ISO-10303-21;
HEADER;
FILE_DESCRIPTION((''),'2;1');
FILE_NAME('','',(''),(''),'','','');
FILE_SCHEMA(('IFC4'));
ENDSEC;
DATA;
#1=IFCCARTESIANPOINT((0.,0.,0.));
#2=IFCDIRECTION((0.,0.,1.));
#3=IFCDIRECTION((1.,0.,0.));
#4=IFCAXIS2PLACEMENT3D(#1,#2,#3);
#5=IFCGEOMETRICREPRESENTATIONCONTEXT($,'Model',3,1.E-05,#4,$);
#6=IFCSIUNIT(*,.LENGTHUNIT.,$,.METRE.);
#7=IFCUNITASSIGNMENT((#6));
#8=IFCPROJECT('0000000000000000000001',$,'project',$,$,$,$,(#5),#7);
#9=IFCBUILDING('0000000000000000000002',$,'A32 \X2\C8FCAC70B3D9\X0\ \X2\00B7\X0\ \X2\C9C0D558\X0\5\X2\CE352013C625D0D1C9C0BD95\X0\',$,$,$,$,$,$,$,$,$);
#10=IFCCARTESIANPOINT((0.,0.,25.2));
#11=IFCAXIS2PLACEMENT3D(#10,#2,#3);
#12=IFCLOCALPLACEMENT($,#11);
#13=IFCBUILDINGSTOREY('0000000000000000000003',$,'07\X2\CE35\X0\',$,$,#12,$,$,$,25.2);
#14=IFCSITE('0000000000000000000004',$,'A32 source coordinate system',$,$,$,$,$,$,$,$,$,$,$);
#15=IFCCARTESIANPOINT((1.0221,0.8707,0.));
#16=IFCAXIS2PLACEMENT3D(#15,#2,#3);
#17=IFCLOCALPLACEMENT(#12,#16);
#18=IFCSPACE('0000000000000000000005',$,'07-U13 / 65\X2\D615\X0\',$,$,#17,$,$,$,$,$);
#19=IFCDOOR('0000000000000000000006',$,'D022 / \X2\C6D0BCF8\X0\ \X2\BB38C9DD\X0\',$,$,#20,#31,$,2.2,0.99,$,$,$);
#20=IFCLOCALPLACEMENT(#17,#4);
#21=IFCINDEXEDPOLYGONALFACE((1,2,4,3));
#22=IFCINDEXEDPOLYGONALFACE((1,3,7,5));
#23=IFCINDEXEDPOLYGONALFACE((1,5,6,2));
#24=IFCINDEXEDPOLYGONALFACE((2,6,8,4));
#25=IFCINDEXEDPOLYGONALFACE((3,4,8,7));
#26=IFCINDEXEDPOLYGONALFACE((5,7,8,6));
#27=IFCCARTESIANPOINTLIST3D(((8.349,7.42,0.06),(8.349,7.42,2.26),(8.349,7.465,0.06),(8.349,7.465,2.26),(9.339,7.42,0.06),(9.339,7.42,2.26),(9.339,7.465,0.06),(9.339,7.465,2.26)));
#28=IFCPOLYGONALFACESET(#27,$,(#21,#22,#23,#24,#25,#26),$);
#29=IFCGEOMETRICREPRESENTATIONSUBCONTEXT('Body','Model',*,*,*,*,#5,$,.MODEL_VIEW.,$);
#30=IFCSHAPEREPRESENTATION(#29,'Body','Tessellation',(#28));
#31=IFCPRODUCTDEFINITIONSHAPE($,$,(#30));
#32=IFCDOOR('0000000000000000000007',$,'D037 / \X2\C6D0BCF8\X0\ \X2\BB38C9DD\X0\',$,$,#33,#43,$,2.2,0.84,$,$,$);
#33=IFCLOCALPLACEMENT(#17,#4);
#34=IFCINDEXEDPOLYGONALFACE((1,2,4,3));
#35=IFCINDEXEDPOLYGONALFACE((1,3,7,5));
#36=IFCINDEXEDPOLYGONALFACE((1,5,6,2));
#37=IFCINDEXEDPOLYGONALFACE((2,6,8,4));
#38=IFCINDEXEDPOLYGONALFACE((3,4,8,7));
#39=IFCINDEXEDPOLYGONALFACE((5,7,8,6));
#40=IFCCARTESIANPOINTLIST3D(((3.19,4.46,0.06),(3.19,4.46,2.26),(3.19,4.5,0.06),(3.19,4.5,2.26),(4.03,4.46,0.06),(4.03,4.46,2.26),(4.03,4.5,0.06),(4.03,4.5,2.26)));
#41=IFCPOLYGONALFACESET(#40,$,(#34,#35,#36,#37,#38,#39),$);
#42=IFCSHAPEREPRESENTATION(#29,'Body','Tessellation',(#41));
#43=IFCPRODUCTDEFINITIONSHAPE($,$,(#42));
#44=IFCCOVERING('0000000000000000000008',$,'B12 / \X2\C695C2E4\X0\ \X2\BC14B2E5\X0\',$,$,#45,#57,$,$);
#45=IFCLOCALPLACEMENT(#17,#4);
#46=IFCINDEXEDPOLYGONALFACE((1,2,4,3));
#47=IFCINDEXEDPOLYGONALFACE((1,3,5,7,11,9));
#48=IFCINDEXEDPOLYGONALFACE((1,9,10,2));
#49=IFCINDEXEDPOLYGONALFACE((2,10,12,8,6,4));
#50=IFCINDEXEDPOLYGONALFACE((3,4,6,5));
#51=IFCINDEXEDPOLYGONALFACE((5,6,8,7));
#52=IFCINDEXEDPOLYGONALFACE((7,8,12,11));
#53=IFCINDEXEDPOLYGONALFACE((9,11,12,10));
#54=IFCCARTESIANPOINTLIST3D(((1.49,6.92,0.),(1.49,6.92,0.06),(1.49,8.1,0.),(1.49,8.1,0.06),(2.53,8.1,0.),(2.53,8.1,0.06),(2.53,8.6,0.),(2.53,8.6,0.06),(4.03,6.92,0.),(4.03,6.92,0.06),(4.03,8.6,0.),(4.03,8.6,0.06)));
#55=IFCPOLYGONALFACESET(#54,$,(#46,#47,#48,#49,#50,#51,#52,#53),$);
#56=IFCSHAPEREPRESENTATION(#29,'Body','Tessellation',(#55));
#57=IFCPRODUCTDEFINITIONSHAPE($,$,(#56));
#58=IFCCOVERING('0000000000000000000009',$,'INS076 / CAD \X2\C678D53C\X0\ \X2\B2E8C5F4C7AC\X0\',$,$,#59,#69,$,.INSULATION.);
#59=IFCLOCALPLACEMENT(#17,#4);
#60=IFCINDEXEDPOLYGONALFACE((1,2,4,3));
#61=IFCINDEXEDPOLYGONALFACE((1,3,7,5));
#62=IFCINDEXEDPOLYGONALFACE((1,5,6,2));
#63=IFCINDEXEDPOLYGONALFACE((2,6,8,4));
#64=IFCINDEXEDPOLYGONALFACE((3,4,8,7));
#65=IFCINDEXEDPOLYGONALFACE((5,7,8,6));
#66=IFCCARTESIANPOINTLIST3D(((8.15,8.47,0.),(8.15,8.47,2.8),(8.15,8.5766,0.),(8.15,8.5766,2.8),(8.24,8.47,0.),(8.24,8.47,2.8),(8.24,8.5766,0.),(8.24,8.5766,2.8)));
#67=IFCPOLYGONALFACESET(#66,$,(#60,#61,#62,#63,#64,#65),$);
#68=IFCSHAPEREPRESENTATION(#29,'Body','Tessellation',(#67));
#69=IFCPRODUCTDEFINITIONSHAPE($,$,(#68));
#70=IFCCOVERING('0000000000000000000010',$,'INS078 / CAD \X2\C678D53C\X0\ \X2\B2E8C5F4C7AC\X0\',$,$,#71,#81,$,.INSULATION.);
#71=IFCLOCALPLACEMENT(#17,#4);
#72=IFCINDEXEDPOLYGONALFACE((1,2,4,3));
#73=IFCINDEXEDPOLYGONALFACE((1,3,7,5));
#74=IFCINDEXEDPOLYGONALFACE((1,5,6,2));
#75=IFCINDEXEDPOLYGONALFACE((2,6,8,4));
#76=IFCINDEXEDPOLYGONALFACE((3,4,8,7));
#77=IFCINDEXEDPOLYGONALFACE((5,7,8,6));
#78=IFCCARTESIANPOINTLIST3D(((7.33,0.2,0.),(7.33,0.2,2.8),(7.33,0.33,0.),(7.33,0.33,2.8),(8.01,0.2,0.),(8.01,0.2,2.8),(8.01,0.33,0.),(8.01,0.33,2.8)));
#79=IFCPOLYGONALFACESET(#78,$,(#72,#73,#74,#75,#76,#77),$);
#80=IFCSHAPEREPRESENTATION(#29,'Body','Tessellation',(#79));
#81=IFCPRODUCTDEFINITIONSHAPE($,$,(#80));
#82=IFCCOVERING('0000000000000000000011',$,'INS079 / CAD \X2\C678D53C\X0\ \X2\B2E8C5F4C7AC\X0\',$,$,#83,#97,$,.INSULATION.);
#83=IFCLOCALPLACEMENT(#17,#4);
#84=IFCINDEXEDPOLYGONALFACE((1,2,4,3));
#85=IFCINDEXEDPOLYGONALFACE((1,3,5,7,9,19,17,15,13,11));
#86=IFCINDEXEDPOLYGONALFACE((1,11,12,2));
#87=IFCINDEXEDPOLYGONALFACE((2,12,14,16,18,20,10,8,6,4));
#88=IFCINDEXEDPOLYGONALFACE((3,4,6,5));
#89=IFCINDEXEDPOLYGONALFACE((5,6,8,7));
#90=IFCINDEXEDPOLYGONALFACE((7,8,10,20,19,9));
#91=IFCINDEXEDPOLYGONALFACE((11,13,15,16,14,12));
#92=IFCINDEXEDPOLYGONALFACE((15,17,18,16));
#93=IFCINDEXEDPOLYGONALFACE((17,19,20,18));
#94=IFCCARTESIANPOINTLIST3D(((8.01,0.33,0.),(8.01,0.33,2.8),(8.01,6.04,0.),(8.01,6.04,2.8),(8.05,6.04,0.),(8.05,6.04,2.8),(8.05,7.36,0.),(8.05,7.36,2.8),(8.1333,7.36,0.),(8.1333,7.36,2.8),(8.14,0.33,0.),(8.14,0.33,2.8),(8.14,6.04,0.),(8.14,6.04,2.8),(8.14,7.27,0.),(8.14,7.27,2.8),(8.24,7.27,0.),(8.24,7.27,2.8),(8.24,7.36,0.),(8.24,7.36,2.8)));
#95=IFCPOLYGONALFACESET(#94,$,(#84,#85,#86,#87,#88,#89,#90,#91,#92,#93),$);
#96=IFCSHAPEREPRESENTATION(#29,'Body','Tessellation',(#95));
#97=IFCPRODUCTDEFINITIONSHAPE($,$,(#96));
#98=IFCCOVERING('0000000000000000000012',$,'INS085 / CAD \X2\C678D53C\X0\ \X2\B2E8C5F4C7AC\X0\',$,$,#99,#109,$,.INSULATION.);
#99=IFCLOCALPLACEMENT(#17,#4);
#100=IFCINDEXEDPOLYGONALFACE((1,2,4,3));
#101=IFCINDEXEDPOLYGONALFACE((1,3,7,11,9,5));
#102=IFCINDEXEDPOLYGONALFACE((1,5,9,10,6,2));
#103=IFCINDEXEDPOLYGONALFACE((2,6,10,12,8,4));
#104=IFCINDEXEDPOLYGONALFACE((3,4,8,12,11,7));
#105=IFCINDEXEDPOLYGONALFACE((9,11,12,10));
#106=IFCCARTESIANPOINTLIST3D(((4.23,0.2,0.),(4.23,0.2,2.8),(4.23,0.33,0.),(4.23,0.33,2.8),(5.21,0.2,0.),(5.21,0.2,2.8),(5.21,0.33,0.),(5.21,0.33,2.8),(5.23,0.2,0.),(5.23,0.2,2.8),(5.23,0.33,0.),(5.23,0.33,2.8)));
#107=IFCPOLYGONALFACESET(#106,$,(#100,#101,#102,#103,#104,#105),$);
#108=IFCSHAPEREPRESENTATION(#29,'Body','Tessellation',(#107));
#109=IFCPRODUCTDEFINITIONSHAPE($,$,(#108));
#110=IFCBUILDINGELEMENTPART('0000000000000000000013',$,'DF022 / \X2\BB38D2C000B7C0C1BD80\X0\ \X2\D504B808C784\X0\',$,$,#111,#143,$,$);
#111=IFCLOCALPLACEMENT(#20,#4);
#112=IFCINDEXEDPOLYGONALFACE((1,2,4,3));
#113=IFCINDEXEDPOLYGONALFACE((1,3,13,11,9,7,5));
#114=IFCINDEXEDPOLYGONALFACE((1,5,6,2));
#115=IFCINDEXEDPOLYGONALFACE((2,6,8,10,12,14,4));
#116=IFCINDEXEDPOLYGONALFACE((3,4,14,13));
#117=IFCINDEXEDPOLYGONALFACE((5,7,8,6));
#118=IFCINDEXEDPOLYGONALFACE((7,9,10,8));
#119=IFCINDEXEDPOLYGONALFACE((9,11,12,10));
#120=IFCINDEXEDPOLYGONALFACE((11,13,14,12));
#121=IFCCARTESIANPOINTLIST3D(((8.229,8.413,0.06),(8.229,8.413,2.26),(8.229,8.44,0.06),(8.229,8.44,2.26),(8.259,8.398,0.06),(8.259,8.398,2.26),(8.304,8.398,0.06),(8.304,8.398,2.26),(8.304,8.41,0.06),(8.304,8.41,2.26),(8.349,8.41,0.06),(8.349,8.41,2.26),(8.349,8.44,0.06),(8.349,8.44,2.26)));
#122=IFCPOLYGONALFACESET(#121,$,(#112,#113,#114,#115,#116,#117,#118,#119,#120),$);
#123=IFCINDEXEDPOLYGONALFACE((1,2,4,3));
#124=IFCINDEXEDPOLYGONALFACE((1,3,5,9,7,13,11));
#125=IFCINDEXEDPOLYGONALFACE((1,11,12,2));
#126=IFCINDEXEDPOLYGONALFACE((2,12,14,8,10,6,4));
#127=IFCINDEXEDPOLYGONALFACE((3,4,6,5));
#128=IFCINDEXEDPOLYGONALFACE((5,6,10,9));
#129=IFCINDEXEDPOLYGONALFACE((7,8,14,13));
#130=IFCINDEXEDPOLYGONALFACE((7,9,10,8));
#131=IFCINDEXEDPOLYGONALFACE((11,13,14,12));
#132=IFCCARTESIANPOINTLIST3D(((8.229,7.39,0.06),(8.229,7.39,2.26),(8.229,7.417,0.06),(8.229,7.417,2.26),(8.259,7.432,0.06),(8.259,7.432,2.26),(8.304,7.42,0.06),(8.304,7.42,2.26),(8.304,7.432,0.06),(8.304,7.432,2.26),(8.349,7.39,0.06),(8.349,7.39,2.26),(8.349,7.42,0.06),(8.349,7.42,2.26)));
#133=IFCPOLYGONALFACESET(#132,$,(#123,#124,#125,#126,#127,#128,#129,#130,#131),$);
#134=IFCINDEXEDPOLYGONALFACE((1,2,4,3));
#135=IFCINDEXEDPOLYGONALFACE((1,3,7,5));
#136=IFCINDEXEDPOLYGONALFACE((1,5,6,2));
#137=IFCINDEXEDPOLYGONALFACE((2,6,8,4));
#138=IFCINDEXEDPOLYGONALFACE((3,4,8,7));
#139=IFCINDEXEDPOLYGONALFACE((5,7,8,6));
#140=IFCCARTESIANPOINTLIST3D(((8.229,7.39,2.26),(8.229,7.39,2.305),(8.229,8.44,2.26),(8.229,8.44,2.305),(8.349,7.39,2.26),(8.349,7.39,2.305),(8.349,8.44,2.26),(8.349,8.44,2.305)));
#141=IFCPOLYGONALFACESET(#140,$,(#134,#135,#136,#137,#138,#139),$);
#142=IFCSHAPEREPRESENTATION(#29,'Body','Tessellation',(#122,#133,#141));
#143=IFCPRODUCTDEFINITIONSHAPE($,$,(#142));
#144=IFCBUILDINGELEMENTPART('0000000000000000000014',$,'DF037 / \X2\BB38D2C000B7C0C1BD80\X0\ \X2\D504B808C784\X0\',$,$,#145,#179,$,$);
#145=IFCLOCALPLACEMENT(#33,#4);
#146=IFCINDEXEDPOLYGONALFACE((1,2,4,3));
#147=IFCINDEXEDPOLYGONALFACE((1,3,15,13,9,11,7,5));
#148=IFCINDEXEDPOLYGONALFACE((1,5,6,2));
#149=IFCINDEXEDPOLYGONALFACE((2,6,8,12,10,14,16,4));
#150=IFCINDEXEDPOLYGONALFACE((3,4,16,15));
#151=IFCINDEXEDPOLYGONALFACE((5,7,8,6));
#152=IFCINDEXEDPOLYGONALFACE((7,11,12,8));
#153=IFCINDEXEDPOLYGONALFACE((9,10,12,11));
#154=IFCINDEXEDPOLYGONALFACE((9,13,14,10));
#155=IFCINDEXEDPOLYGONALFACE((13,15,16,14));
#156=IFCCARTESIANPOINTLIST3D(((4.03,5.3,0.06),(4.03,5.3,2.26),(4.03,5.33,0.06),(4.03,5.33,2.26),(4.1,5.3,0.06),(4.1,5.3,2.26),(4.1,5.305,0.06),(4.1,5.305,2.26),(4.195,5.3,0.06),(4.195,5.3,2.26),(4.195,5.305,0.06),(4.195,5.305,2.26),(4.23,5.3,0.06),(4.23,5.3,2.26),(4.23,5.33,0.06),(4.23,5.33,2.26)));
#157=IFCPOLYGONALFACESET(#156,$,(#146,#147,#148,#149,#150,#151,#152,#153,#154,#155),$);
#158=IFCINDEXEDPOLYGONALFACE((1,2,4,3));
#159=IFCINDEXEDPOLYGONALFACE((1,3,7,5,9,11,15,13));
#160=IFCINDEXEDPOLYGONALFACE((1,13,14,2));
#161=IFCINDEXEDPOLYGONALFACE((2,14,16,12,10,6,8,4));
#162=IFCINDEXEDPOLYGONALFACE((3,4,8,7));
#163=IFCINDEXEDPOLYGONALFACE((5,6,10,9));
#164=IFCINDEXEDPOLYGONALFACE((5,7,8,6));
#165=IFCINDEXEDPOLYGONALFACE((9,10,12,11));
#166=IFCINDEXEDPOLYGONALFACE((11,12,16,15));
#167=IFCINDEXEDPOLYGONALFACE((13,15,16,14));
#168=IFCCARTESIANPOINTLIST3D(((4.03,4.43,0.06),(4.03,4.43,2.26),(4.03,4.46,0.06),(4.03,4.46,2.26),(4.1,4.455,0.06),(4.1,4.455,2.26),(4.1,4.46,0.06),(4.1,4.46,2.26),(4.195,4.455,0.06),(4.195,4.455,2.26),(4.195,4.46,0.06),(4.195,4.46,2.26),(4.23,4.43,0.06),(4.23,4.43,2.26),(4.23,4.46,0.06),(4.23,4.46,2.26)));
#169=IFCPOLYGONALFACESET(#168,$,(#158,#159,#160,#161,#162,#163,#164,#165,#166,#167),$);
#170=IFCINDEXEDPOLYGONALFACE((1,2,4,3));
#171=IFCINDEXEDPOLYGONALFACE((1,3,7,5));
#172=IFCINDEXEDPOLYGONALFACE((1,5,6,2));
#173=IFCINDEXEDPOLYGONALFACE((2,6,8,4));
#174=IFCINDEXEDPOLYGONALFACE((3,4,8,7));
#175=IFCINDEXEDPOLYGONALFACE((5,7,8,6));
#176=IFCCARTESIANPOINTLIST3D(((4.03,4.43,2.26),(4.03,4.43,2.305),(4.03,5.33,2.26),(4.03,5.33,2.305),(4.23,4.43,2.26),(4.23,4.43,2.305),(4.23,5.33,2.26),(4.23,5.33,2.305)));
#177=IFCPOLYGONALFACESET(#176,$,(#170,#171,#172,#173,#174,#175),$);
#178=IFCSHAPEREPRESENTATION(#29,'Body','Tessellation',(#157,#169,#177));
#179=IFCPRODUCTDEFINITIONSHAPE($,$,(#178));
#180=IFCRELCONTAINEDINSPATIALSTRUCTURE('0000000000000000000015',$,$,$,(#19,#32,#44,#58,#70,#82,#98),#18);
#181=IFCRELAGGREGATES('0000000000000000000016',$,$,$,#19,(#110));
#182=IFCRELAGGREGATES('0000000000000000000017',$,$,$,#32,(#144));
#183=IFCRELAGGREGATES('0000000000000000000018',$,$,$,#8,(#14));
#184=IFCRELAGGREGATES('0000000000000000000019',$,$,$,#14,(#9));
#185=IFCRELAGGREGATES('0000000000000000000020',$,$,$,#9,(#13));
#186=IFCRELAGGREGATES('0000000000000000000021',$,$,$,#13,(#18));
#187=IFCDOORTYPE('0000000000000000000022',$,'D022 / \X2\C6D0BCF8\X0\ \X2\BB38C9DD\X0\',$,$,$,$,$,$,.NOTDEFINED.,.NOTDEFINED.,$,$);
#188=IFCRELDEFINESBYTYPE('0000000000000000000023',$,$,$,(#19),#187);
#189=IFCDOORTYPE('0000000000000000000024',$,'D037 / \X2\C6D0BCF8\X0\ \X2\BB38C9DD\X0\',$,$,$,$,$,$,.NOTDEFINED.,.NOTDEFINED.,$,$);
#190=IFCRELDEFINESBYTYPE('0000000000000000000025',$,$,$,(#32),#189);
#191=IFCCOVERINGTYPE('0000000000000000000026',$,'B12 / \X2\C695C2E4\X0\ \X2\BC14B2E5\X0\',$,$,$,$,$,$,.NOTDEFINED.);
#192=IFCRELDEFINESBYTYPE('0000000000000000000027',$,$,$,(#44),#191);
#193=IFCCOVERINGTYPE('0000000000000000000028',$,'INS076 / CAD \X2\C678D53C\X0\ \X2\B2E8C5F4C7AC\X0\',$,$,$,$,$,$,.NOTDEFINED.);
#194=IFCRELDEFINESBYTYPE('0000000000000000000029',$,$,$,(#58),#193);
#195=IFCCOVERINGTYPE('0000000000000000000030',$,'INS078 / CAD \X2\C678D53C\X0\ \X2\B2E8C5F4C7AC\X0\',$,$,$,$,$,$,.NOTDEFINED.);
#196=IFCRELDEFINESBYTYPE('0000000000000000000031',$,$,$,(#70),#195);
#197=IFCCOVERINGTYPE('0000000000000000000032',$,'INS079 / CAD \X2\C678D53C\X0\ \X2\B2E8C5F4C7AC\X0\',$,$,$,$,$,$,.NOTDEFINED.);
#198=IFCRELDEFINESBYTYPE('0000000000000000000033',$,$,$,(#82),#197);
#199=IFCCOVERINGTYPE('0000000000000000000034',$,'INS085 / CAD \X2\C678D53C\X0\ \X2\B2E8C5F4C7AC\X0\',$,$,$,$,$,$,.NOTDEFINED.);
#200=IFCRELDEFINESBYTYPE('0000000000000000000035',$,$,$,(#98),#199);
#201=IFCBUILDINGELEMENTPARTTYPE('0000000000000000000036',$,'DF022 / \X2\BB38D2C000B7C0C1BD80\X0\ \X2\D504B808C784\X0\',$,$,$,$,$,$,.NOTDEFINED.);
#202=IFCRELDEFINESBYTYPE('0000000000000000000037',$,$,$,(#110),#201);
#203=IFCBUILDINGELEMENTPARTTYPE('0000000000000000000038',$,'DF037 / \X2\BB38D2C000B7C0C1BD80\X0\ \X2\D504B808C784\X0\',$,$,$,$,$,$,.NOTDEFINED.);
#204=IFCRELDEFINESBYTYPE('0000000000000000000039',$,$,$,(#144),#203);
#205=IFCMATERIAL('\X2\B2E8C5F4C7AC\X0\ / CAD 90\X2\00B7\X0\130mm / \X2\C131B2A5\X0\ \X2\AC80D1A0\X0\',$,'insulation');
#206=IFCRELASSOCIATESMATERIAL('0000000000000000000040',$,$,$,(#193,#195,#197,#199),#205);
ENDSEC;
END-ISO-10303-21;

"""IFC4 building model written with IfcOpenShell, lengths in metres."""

from ifc_helpers import new_model, si_unit, frame, origin, origin_with_axes, place, context, subcontext, project, spatial, polyline, outline, extrude, source, transform, mapped, material, type_object, type_shapes, element, aggregate, save


model = new_model("IFC4")

# Units and contexts
model_context = context("Model", 3, precision=1e-05, world=origin_with_axes())
body_context = subcontext(model_context, "Body", "Model", "MODEL_VIEW")
ifc_project = project(units=[si_unit("LENGTHUNIT", "METRE")], contexts=[model_context])

# Site, building, storey
site = spatial("IfcSite", under=ifc_project, Name="A32 source coordinate system")
building = spatial("IfcBuilding", under=site, Name="A32 주거동 · 지하5층–옥탑지붕")
storey_placement = place(None, frame((0.0, 0.0, 25.2), z_axis=(0.0, 0.0, 1.0), x_axis=(1.0, 0.0, 0.0)))
storey = spatial("IfcBuildingStorey", under=building, at=storey_placement, Name="07층", Elevation=25.2)

# Shared definitions
space_placement = place(storey_placement, frame((1.0221, 0.8707, 0.0), z_axis=(0.0, 0.0, 1.0), x_axis=(1.0, 0.0, 0.0)))
space = spatial("IfcSpace", under=storey, at=space_placement, Name="07-U13 / 65형")

# Doors
door_type_1 = type_object("IfcDoorType", Name="D022 / 원본 문짝", OperationType="NOTDEFINED", PredefinedType="NOTDEFINED")
shared_shape_1 = source(origin(), body_context, "Body", "SweptSolid", [
    extrude(outline(polyline([(9.339, 7.465), (9.339, 7.42), (8.349, 7.42), (8.349, 7.465), (9.339, 7.465)])), frame((0.0, 0.0, 0.06)), (0.0, 0.0, 1.0), 2.2),
])
type_shapes(door_type_1, [shared_shape_1])
door_1_placement = place(space_placement, origin_with_axes())
door_1 = element("IfcDoor", 1, at=door_1_placement, inside=space, type_object=door_type_1, Name="D022 / 원본 문짝", OverallHeight=2.2, OverallWidth=0.99, context=body_context, shape_type="MappedRepresentation", body=[
    mapped(shared_shape_1, transform((0.0, 0.0, 0.0), scale=1.0)),
])
door_type_2 = type_object("IfcDoorType", Name="D037 / 원본 문짝", OperationType="NOTDEFINED", PredefinedType="NOTDEFINED")
shared_shape_2 = source(origin(), body_context, "Body", "SweptSolid", [
    extrude(outline(polyline([(4.03, 4.46), (3.19, 4.46), (3.19, 4.5), (4.03, 4.5), (4.03, 4.46)])), frame((0.0, 0.0, 0.06)), (0.0, 0.0, 1.0), 2.2),
])
type_shapes(door_type_2, [shared_shape_2])
door_2_placement = place(space_placement, origin_with_axes())
door_2 = element("IfcDoor", 2, at=door_2_placement, inside=space, type_object=door_type_2, Name="D037 / 원본 문짝", OverallHeight=2.2, OverallWidth=0.84, context=body_context, shape_type="MappedRepresentation", body=[
    mapped(shared_shape_2, transform((0.0, 0.0, 0.0), scale=1.0)),
])

# Coverings
covering_type_1 = type_object("IfcCoveringType", Name="B12 / 욕실 바닥", PredefinedType="NOTDEFINED")
shared_shape_3 = source(origin(), body_context, "Body", "SweptSolid", [
    extrude(outline(polyline([(2.53, 8.6), (4.03, 8.6), (4.03, 6.92), (1.49, 6.92), (1.49, 8.1), (2.53, 8.1), (2.53, 8.6)])), origin(), (0.0, 0.0, 1.0), 0.06),
])
type_shapes(covering_type_1, [shared_shape_3])
covering_1_placement = place(space_placement, origin_with_axes())
element("IfcCovering", 3, at=covering_1_placement, inside=space, type_object=covering_type_1, Name="B12 / 욕실 바닥", context=body_context, shape_type="MappedRepresentation", body=[
    mapped(shared_shape_3, transform((0.0, 0.0, 0.0), scale=1.0)),
])
ifc_material = material(Name="단열재 / CAD 90·130mm / 성능 검토", Category="insulation")
covering_type_2 = type_object("IfcCoveringType", Name="INS076 / CAD 외피 단열재", PredefinedType="NOTDEFINED", material=ifc_material)
shared_shape_4 = source(origin(), body_context, "Body", "SweptSolid", [
    extrude(outline(polyline([(8.24, 8.5766), (8.24, 8.47), (8.15, 8.47), (8.15, 8.5766), (8.24, 8.5766)])), origin(), (0.0, 0.0, 1.0), 2.8),
])
type_shapes(covering_type_2, [shared_shape_4])
covering_2_placement = place(space_placement, origin_with_axes())
element("IfcCovering", 4, at=covering_2_placement, inside=space, type_object=covering_type_2, Name="INS076 / CAD 외피 단열재", PredefinedType="INSULATION", context=body_context, shape_type="MappedRepresentation", body=[
    mapped(shared_shape_4, transform((0.0, 0.0, 0.0), scale=1.0)),
])
covering_type_3 = type_object("IfcCoveringType", Name="INS078 / CAD 외피 단열재", PredefinedType="NOTDEFINED", material=ifc_material)
shared_shape_5 = source(origin(), body_context, "Body", "SweptSolid", [
    extrude(outline(polyline([(8.01, 0.2), (7.33, 0.2), (7.33, 0.33), (8.01, 0.33), (8.01, 0.2)])), origin(), (0.0, 0.0, 1.0), 2.8),
])
type_shapes(covering_type_3, [shared_shape_5])
covering_3_placement = place(space_placement, origin_with_axes())
element("IfcCovering", 5, at=covering_3_placement, inside=space, type_object=covering_type_3, Name="INS078 / CAD 외피 단열재", PredefinedType="INSULATION", context=body_context, shape_type="MappedRepresentation", body=[
    mapped(shared_shape_5, transform((0.0, 0.0, 0.0), scale=1.0)),
])
covering_type_4 = type_object("IfcCoveringType", Name="INS079 / CAD 외피 단열재", PredefinedType="NOTDEFINED", material=ifc_material)
shared_shape_6 = source(origin(), body_context, "Body", "SweptSolid", [
    extrude(outline(polyline([(8.24, 7.27), (8.14, 7.27), (8.14, 6.04), (8.14, 0.33), (8.01, 0.33), (8.01, 6.04), (8.05, 6.04), (8.05, 7.36), (8.1333, 7.36), (8.24, 7.36), (8.24, 7.27)])), origin(), (0.0, 0.0, 1.0), 2.8),
])
type_shapes(covering_type_4, [shared_shape_6])
covering_4_placement = place(space_placement, origin_with_axes())
element("IfcCovering", 6, at=covering_4_placement, inside=space, type_object=covering_type_4, Name="INS079 / CAD 외피 단열재", PredefinedType="INSULATION", context=body_context, shape_type="MappedRepresentation", body=[
    mapped(shared_shape_6, transform((0.0, 0.0, 0.0), scale=1.0)),
])
covering_type_5 = type_object("IfcCoveringType", Name="INS085 / CAD 외피 단열재", PredefinedType="NOTDEFINED", material=ifc_material)
shared_shape_7 = source(origin(), body_context, "Body", "SweptSolid", [
    extrude(outline(polyline([(4.23, 0.2), (4.23, 0.33), (5.21, 0.33), (5.23, 0.33), (5.23, 0.2), (5.21, 0.2), (4.23, 0.2)])), origin(), (0.0, 0.0, 1.0), 2.8),
])
type_shapes(covering_type_5, [shared_shape_7])
covering_5_placement = place(space_placement, origin_with_axes())
element("IfcCovering", 7, at=covering_5_placement, inside=space, type_object=covering_type_5, Name="INS085 / CAD 외피 단열재", PredefinedType="INSULATION", context=body_context, shape_type="MappedRepresentation", body=[
    mapped(shared_shape_7, transform((0.0, 0.0, 0.0), scale=1.0)),
])

# Building element parts
building_element_part_type_1 = type_object("IfcBuildingElementPartType", Name="DF022 / 문틀·상부 프레임", PredefinedType="NOTDEFINED")
shared_shape_8 = source(origin(), body_context, "Body", "SweptSolid", [
    extrude(outline(polyline([(8.349, 8.41), (8.304, 8.41), (8.304, 8.398), (8.259, 8.398), (8.229, 8.413), (8.229, 8.44), (8.349, 8.44), (8.349, 8.41)])), frame((0.0, 0.0, 0.06)), (0.0, 0.0, 1.0), 2.2),
    extrude(outline(polyline([(8.229, 7.39), (8.229, 7.417), (8.259, 7.432), (8.304, 7.432), (8.304, 7.42), (8.349, 7.42), (8.349, 7.39), (8.229, 7.39)])), frame((0.0, 0.0, 0.06)), (0.0, 0.0, 1.0), 2.2),
    extrude(outline(polyline([(8.229, 7.39), (8.229, 8.44), (8.349, 8.44), (8.349, 7.39), (8.229, 7.39)])), frame((0.0, 0.0, 2.26)), (0.0, 0.0, 1.0), 0.045),
])
type_shapes(building_element_part_type_1, [shared_shape_8])
building_element_part_1_placement = place(door_1_placement, origin_with_axes())
building_element_part_1 = element("IfcBuildingElementPart", 8, at=building_element_part_1_placement, type_object=building_element_part_type_1, Name="DF022 / 문틀·상부 프레임", context=body_context, shape_type="MappedRepresentation", body=[
    mapped(shared_shape_8, transform((0.0, 0.0, 0.0), scale=1.0)),
])
aggregate(door_1, [building_element_part_1])
building_element_part_type_2 = type_object("IfcBuildingElementPartType", Name="DF037 / 문틀·상부 프레임", PredefinedType="NOTDEFINED")
shared_shape_9 = source(origin(), body_context, "Body", "SweptSolid", [
    extrude(outline(polyline([(4.23, 5.33), (4.23, 5.3), (4.195, 5.3), (4.195, 5.305), (4.1, 5.305), (4.1, 5.3), (4.03, 5.3), (4.03, 5.33), (4.23, 5.33)])), frame((0.0, 0.0, 0.06)), (0.0, 0.0, 1.0), 2.2),
    extrude(outline(polyline([(4.03, 4.46), (4.1, 4.46), (4.1, 4.455), (4.195, 4.455), (4.195, 4.46), (4.23, 4.46), (4.23, 4.43), (4.03, 4.43), (4.03, 4.46)])), frame((0.0, 0.0, 0.06)), (0.0, 0.0, 1.0), 2.2),
    extrude(outline(polyline([(4.03, 4.43), (4.03, 5.33), (4.23, 5.33), (4.23, 4.43), (4.03, 4.43)])), frame((0.0, 0.0, 2.26)), (0.0, 0.0, 1.0), 0.045),
])
type_shapes(building_element_part_type_2, [shared_shape_9])
building_element_part_2_placement = place(door_2_placement, origin_with_axes())
building_element_part_2 = element("IfcBuildingElementPart", 9, at=building_element_part_2_placement, type_object=building_element_part_type_2, Name="DF037 / 문틀·상부 프레임", context=body_context, shape_type="MappedRepresentation", body=[
    mapped(shared_shape_9, transform((0.0, 0.0, 0.0), scale=1.0)),
])
aggregate(door_2, [building_element_part_2])

save(model, "model.ifc")
